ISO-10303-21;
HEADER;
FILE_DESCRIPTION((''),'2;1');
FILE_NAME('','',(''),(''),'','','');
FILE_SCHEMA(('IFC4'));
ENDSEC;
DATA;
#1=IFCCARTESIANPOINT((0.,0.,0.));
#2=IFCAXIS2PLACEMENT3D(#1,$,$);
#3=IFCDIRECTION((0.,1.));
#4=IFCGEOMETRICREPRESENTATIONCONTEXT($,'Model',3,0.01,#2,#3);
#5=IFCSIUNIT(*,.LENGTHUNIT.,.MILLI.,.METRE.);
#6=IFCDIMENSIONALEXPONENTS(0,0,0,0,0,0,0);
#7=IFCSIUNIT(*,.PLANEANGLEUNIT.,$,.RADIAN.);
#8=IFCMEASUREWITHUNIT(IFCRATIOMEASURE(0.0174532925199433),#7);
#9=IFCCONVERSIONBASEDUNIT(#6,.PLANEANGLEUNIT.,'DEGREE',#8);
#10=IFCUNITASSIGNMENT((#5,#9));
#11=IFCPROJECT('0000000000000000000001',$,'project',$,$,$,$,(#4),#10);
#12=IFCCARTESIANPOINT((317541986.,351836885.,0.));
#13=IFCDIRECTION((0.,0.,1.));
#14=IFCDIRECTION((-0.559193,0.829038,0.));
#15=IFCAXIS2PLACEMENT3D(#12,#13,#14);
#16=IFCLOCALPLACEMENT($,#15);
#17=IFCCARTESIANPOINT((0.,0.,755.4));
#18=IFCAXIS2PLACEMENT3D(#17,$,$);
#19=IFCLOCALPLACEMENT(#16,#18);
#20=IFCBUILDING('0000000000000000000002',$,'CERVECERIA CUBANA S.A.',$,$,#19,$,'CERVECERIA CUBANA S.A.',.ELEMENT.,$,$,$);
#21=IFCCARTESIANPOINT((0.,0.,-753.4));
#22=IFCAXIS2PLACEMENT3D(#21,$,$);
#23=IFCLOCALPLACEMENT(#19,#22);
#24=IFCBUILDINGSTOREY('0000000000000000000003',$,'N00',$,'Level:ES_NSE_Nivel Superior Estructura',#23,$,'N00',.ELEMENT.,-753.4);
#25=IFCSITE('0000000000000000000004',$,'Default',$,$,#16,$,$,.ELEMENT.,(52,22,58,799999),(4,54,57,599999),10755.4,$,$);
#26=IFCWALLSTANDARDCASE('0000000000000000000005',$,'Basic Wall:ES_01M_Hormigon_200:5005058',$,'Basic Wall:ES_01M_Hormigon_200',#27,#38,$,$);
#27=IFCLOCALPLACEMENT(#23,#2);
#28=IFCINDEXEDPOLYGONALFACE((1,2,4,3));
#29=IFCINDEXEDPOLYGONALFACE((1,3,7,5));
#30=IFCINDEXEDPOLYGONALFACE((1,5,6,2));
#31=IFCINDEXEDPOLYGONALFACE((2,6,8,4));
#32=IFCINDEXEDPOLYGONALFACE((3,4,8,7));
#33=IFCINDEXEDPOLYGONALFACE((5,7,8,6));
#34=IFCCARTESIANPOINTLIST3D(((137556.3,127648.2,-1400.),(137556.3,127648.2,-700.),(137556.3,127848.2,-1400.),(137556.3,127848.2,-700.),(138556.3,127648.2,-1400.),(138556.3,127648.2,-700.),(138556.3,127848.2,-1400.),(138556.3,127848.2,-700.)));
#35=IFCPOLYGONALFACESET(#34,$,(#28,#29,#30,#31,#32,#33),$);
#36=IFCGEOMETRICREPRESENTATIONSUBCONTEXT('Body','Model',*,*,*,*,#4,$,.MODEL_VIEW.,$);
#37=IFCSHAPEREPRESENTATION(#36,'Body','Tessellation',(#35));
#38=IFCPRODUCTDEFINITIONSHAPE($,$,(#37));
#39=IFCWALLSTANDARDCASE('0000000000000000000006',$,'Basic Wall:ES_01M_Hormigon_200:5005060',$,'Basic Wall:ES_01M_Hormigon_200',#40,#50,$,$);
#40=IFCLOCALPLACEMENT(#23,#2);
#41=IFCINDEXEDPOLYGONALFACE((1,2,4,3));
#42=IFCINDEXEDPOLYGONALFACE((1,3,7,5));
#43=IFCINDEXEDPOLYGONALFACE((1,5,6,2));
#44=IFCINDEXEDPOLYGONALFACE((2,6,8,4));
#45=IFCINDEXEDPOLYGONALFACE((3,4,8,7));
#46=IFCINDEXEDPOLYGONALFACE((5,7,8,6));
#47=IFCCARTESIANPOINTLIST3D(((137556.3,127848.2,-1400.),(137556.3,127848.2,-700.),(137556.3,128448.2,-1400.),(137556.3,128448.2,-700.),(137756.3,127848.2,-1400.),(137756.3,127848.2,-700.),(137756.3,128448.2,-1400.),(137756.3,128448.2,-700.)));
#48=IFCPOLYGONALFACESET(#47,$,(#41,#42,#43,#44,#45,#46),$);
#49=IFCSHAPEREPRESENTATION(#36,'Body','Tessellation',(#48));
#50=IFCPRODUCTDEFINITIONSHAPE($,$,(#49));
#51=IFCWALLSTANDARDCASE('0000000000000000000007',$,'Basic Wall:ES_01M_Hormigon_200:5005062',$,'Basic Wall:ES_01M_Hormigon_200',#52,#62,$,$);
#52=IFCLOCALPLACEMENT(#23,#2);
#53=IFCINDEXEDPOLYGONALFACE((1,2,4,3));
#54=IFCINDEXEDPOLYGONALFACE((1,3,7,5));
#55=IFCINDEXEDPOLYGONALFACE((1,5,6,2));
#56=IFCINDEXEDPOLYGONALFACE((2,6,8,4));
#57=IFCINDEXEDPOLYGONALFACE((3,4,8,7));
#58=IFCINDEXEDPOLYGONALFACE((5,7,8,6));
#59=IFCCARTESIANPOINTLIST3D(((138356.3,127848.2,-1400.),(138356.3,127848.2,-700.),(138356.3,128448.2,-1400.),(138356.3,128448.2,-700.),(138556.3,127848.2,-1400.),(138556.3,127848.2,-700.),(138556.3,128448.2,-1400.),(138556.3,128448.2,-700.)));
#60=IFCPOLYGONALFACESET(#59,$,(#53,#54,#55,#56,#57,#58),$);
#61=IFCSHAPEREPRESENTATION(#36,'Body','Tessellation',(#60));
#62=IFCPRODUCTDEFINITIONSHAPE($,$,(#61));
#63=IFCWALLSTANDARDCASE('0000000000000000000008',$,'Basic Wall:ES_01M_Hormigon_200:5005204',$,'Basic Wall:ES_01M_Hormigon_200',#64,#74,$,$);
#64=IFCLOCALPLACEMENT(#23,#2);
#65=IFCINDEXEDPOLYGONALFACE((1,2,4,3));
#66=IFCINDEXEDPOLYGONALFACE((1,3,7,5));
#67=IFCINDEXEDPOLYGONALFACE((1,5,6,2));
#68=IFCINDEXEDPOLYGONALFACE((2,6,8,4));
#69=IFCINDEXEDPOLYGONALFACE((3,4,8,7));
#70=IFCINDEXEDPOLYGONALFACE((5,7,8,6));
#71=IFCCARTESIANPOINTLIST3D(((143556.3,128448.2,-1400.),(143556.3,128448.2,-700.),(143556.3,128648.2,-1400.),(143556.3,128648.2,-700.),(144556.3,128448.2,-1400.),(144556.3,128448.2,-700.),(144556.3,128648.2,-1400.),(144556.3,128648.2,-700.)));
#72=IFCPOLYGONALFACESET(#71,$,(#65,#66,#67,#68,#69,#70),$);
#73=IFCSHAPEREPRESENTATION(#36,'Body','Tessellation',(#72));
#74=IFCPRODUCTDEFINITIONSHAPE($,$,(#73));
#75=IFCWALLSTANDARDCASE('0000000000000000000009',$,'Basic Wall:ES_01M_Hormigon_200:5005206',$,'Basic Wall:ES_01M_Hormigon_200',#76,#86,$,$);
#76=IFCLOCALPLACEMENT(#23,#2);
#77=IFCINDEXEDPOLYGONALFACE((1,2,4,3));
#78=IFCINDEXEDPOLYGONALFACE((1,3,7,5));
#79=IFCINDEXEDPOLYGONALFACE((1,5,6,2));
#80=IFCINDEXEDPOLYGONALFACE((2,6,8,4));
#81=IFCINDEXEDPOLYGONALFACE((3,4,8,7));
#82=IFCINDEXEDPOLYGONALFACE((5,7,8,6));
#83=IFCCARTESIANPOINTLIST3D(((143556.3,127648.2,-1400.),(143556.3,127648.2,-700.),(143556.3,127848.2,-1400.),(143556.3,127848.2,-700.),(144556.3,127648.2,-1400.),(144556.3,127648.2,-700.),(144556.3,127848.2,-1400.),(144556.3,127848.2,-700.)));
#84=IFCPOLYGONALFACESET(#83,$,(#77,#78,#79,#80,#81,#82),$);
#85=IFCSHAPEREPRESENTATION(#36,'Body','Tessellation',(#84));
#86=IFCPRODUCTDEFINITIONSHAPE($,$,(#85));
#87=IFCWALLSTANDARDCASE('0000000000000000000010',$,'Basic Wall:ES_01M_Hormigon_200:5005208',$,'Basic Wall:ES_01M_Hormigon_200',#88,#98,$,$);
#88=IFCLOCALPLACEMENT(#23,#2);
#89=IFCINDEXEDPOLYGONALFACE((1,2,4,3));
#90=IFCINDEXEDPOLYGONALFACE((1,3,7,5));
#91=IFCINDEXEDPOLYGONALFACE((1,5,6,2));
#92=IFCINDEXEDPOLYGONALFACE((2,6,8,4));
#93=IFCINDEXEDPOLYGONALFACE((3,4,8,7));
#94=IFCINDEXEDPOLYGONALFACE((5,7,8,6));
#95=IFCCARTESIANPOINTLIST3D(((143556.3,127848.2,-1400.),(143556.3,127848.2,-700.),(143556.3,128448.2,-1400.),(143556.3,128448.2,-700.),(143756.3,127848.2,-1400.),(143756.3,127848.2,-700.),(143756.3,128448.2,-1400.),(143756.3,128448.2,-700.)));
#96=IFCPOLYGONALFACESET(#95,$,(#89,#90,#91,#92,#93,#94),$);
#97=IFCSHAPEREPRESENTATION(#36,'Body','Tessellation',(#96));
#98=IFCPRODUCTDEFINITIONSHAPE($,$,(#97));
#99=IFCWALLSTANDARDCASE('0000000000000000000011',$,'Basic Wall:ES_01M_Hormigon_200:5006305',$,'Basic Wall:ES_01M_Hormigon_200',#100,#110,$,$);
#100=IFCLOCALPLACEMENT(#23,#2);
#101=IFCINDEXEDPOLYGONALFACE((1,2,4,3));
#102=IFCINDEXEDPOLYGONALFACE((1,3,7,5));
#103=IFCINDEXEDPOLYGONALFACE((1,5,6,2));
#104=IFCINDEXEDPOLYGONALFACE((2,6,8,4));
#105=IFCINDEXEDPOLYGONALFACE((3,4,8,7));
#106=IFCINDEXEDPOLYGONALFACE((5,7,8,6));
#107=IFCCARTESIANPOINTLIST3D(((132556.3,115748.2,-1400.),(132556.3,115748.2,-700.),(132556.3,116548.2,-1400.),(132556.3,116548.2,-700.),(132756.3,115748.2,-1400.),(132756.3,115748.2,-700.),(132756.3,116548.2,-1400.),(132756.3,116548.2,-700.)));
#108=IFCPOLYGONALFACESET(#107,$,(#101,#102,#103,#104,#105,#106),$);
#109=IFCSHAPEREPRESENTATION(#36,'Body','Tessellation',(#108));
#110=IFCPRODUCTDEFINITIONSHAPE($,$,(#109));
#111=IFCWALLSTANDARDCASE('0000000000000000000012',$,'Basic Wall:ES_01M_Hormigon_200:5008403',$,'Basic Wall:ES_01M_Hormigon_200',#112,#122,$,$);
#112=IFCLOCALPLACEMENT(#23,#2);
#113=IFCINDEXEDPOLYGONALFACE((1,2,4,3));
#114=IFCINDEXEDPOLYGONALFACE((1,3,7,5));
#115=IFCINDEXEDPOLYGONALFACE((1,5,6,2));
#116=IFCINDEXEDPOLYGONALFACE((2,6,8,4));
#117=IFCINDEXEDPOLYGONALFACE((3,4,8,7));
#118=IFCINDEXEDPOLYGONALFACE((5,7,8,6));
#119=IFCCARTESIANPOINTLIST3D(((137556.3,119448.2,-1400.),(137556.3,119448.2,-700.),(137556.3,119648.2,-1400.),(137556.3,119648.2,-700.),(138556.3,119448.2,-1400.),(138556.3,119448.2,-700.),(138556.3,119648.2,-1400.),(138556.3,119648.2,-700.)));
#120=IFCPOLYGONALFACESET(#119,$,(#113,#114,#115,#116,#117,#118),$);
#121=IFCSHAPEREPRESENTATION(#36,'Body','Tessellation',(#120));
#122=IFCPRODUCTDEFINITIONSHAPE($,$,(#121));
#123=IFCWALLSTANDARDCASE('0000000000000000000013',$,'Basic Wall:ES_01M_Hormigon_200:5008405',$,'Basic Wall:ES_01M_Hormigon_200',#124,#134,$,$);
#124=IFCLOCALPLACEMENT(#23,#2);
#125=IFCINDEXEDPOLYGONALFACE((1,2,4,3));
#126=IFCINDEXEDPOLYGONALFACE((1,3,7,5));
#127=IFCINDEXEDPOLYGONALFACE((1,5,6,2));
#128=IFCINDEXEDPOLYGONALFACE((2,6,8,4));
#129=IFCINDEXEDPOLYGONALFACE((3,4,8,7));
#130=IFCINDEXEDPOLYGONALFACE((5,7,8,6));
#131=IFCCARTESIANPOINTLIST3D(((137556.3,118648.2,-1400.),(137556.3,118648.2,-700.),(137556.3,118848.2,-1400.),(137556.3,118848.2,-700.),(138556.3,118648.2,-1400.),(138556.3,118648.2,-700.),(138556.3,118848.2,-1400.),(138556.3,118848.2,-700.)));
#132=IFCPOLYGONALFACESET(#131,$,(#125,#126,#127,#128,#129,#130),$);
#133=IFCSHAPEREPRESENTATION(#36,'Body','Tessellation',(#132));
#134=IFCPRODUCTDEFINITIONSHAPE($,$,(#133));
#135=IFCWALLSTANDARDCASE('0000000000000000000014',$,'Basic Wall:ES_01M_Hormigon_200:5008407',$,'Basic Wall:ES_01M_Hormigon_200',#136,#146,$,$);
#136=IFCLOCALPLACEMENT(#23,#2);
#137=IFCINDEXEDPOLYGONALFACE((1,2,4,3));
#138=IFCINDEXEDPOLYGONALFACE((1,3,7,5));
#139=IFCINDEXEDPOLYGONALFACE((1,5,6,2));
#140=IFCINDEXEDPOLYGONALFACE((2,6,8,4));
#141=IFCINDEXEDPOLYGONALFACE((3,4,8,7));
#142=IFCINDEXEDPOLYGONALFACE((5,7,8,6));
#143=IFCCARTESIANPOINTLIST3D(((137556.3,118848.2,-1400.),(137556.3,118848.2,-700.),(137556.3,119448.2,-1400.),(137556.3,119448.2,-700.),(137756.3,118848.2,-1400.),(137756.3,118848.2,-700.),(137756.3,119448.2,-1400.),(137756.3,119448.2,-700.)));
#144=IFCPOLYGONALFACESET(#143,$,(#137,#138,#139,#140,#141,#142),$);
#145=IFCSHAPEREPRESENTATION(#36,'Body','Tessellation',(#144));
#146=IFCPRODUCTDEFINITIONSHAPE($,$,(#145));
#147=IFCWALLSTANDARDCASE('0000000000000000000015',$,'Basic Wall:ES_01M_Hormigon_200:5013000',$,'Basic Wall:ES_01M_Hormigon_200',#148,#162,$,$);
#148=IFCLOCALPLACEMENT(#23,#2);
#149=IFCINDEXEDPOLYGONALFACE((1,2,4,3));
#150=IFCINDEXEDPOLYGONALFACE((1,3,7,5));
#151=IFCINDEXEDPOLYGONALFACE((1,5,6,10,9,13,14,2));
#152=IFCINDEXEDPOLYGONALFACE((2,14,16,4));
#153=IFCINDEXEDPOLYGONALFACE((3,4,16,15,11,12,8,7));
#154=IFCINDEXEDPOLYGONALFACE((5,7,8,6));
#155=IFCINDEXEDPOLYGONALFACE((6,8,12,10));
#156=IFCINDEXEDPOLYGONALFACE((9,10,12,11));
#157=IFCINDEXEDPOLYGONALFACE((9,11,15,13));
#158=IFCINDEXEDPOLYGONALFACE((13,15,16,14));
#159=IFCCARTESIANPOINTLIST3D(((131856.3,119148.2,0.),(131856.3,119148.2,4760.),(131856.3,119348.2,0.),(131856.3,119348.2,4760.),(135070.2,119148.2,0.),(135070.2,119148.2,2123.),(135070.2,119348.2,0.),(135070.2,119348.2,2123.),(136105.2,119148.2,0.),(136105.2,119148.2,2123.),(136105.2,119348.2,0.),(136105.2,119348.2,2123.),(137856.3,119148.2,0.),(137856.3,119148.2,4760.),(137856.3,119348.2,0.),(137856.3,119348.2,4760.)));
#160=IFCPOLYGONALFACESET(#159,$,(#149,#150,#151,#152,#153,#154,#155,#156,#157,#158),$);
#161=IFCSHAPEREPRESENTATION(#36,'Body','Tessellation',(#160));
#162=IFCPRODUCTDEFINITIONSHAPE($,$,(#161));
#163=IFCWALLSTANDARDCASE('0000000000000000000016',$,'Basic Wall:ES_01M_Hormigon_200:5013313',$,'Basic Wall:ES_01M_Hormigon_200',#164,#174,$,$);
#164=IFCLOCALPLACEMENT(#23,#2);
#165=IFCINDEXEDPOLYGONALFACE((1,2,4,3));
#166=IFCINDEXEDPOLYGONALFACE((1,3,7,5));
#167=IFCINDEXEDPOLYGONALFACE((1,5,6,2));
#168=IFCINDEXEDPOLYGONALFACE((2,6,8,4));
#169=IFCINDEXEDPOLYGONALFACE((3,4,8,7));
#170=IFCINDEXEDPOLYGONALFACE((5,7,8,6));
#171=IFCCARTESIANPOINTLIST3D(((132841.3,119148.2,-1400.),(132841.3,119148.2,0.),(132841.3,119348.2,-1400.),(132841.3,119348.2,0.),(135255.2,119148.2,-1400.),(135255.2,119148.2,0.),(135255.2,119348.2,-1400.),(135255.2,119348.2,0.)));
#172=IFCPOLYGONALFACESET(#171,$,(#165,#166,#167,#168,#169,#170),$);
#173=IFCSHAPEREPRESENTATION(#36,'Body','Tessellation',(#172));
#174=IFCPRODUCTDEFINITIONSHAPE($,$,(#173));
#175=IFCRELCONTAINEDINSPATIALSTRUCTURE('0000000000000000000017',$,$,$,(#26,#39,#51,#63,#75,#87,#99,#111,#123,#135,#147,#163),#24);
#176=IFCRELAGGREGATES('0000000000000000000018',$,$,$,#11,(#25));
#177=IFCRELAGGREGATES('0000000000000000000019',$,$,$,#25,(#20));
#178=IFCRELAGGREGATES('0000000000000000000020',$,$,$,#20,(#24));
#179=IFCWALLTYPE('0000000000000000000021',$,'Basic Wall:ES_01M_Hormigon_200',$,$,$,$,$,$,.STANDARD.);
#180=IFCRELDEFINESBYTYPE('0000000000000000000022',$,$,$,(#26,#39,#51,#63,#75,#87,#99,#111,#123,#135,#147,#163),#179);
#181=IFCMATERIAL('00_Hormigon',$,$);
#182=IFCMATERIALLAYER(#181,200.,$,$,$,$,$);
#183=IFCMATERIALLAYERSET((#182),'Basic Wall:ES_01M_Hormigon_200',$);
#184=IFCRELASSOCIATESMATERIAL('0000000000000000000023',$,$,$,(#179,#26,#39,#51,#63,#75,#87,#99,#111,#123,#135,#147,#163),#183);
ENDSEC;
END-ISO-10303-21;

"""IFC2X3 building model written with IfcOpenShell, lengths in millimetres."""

from ifc_helpers import new_model, entity, si_unit, converted_unit, direction, frame, frame_2d, origin, place, context, subcontext, project, spatial, rectangle, extrude, material, layer, layer_set, layer_usage, type_object, element, save


model = new_model("IFC2X3")

# Units and contexts
model_context = context("Model", 3, precision=0.01, world=origin(), true_north=direction((0.0, 1.0)))
body_context = subcontext(model_context, "Body", "Model", "MODEL_VIEW")
ifc_project = project(units=[si_unit("LENGTHUNIT", "METRE", prefix="MILLI"), converted_unit("PLANEANGLEUNIT", "DEGREE", entity("IfcRatioMeasure", 0.0174532925199433), si_unit("PLANEANGLEUNIT", "RADIAN"), dimensions=[0, 0, 0, 0, 0, 0, 0])], contexts=[model_context])

# Site, building, storey
site_placement = place(None, frame((317541986.0, 351836885.0, 0.0), z_axis=(0.0, 0.0, 1.0), x_axis=(-0.559193, 0.829038, 0.0)))
site = spatial("IfcSite", under=ifc_project, at=site_placement, Name="Default", CompositionType="ELEMENT", RefLatitude=(52, 22, 58, 799999), RefLongitude=(4, 54, 57, 599999), RefElevation=10755.4)
building_placement = place(site_placement, frame((0.0, 0.0, 755.4)))
building = spatial("IfcBuilding", under=site, at=building_placement, Name="CERVECERIA CUBANA S.A.", LongName="CERVECERIA CUBANA S.A.", CompositionType="ELEMENT")
storey_placement = place(building_placement, frame((0.0, 0.0, -753.4)))
storey = spatial("IfcBuildingStorey", under=building, at=storey_placement, Name="N00", ObjectType="Level:ES_NSE_Nivel Superior Estructura", LongName="N00", CompositionType="ELEMENT", Elevation=-753.4)

# Walls
ifc_material = material(Name="00_Hormigon")
ifc_layer = layer(ifc_material, 200.0)
ifc_layer_set = layer_set([ifc_layer], Name="Basic Wall:ES_01M_Hormigon_200")
wall_type = type_object("IfcWallType", Name="Basic Wall:ES_01M_Hormigon_200", PredefinedType="STANDARD", material=ifc_layer_set)
ifc_layer_usage_1 = layer_usage(ifc_layer_set, "AXIS2", "POSITIVE", -100.0)
wall_1_placement = place(storey_placement, frame((137556.3, 127748.2, -1400.0)))
element("IfcWallStandardCase", 1, at=wall_1_placement, inside=storey, type_object=wall_type, material=ifc_layer_usage_1, Name="Basic Wall:ES_01M_Hormigon_200:5005058", ObjectType="Basic Wall:ES_01M_Hormigon_200", context=body_context, shape_type="SweptSolid", body=[
    extrude(rectangle(XDim=1000.0, YDim=200.0, at=frame_2d((500.0, 0.0), x_axis=(-1.0, 0.0))), origin(), (0.0, 0.0, 1.0), 700.0),
])
ifc_layer_usage_2 = layer_usage(ifc_layer_set, "AXIS2", "POSITIVE", -100.0)
wall_2_placement = place(storey_placement, frame((137656.3, 128448.2, -1400.0), z_axis=(0.0, 0.0, 1.0), x_axis=(0.0, -1.0, 0.0)))
element("IfcWallStandardCase", 2, at=wall_2_placement, inside=storey, type_object=wall_type, material=ifc_layer_usage_2, Name="Basic Wall:ES_01M_Hormigon_200:5005060", ObjectType="Basic Wall:ES_01M_Hormigon_200", context=body_context, shape_type="SweptSolid", body=[
    extrude(rectangle(XDim=600.0, YDim=200.0, at=frame_2d((300.0, 0.0), x_axis=(-1.0, 0.0))), origin(), (0.0, 0.0, 1.0), 700.0),
])
ifc_layer_usage_3 = layer_usage(ifc_layer_set, "AXIS2", "NEGATIVE", 100.0)
wall_3_placement = place(storey_placement, frame((138456.3, 128448.2, -1400.0), z_axis=(0.0, 0.0, 1.0), x_axis=(0.0, -1.0, 0.0)))
element("IfcWallStandardCase", 3, at=wall_3_placement, inside=storey, type_object=wall_type, material=ifc_layer_usage_3, Name="Basic Wall:ES_01M_Hormigon_200:5005062", ObjectType="Basic Wall:ES_01M_Hormigon_200", context=body_context, shape_type="SweptSolid", body=[
    extrude(rectangle(XDim=600.0, YDim=200.0, at=frame_2d((300.0, 0.0), x_axis=(-1.0, 0.0))), origin(), (0.0, 0.0, 1.0), 700.0),
])
ifc_layer_usage_4 = layer_usage(ifc_layer_set, "AXIS2", "NEGATIVE", 100.0)
wall_4_placement = place(storey_placement, frame((143556.3, 128548.2, -1400.0)))
element("IfcWallStandardCase", 4, at=wall_4_placement, inside=storey, type_object=wall_type, material=ifc_layer_usage_4, Name="Basic Wall:ES_01M_Hormigon_200:5005204", ObjectType="Basic Wall:ES_01M_Hormigon_200", context=body_context, shape_type="SweptSolid", body=[
    extrude(rectangle(XDim=1000.0, YDim=200.0, at=frame_2d((500.0, 0.0), x_axis=(-1.0, 0.0))), origin(), (0.0, 0.0, 1.0), 700.0),
])
ifc_layer_usage_5 = layer_usage(ifc_layer_set, "AXIS2", "POSITIVE", -100.0)
wall_5_placement = place(storey_placement, frame((143556.3, 127748.2, -1400.0)))
element("IfcWallStandardCase", 5, at=wall_5_placement, inside=storey, type_object=wall_type, material=ifc_layer_usage_5, Name="Basic Wall:ES_01M_Hormigon_200:5005206", ObjectType="Basic Wall:ES_01M_Hormigon_200", context=body_context, shape_type="SweptSolid", body=[
    extrude(rectangle(XDim=1000.0, YDim=200.0, at=frame_2d((500.0, 0.0), x_axis=(-1.0, 0.0))), origin(), (0.0, 0.0, 1.0), 700.0),
])
ifc_layer_usage_6 = layer_usage(ifc_layer_set, "AXIS2", "POSITIVE", -100.0)
wall_6_placement = place(storey_placement, frame((143656.3, 128448.2, -1400.0), z_axis=(0.0, 0.0, 1.0), x_axis=(0.0, -1.0, 0.0)))
element("IfcWallStandardCase", 6, at=wall_6_placement, inside=storey, type_object=wall_type, material=ifc_layer_usage_6, Name="Basic Wall:ES_01M_Hormigon_200:5005208", ObjectType="Basic Wall:ES_01M_Hormigon_200", context=body_context, shape_type="SweptSolid", body=[
    extrude(rectangle(XDim=600.0, YDim=200.0, at=frame_2d((300.0, 0.0), x_axis=(-1.0, 0.0))), origin(), (0.0, 0.0, 1.0), 700.0),
])
ifc_layer_usage_7 = layer_usage(ifc_layer_set, "AXIS2", "NEGATIVE", 100.0)
wall_7_placement = place(storey_placement, frame((132656.3, 116548.2, -1400.0), z_axis=(0.0, 0.0, 1.0), x_axis=(0.0, -1.0, 0.0)))
element("IfcWallStandardCase", 7, at=wall_7_placement, inside=storey, type_object=wall_type, material=ifc_layer_usage_7, Name="Basic Wall:ES_01M_Hormigon_200:5006305", ObjectType="Basic Wall:ES_01M_Hormigon_200", context=body_context, shape_type="SweptSolid", body=[
    extrude(rectangle(XDim=800.0, YDim=200.0, at=frame_2d((400.0, 0.0), x_axis=(-1.0, 0.0))), origin(), (0.0, 0.0, 1.0), 700.0),
])
ifc_layer_usage_8 = layer_usage(ifc_layer_set, "AXIS2", "NEGATIVE", 100.0)
wall_8_placement = place(storey_placement, frame((137556.3, 119548.2, -1400.0)))
element("IfcWallStandardCase", 8, at=wall_8_placement, inside=storey, type_object=wall_type, material=ifc_layer_usage_8, Name="Basic Wall:ES_01M_Hormigon_200:5008403", ObjectType="Basic Wall:ES_01M_Hormigon_200", context=body_context, shape_type="SweptSolid", body=[
    extrude(rectangle(XDim=1000.0, YDim=200.0, at=frame_2d((500.0, 0.0), x_axis=(-1.0, 0.0))), origin(), (0.0, 0.0, 1.0), 700.0),
])
ifc_layer_usage_9 = layer_usage(ifc_layer_set, "AXIS2", "POSITIVE", -100.0)
wall_9_placement = place(storey_placement, frame((137556.3, 118748.2, -1400.0)))
element("IfcWallStandardCase", 9, at=wall_9_placement, inside=storey, type_object=wall_type, material=ifc_layer_usage_9, Name="Basic Wall:ES_01M_Hormigon_200:5008405", ObjectType="Basic Wall:ES_01M_Hormigon_200", context=body_context, shape_type="SweptSolid", body=[
    extrude(rectangle(XDim=1000.0, YDim=200.0, at=frame_2d((500.0, 0.0), x_axis=(-1.0, 0.0))), origin(), (0.0, 0.0, 1.0), 700.0),
])
ifc_layer_usage_10 = layer_usage(ifc_layer_set, "AXIS2", "POSITIVE", -100.0)
wall_10_placement = place(storey_placement, frame((137656.3, 119448.2, -1400.0), z_axis=(0.0, 0.0, 1.0), x_axis=(0.0, -1.0, 0.0)))
element("IfcWallStandardCase", 10, at=wall_10_placement, inside=storey, type_object=wall_type, material=ifc_layer_usage_10, Name="Basic Wall:ES_01M_Hormigon_200:5008407", ObjectType="Basic Wall:ES_01M_Hormigon_200", context=body_context, shape_type="SweptSolid", body=[
    extrude(rectangle(XDim=600.0, YDim=200.0, at=frame_2d((300.0, 0.0), x_axis=(-1.0, 0.0))), origin(), (0.0, 0.0, 1.0), 700.0),
])

# Wall, opening
ifc_layer_usage_11 = layer_usage(ifc_layer_set, "AXIS2", "NEGATIVE", 100.0)
wall_11_placement = place(storey_placement, frame((131856.3, 119248.2, 0.0)))
wall_11 = element("IfcWallStandardCase", 11, at=wall_11_placement, inside=storey, type_object=wall_type, material=ifc_layer_usage_11, Name="Basic Wall:ES_01M_Hormigon_200:5013000", ObjectType="Basic Wall:ES_01M_Hormigon_200", context=body_context, shape_type="SweptSolid", body=[
    extrude(rectangle(XDim=6000.0, YDim=200.0, at=frame_2d((3000.0, 0.0), x_axis=(-1.0, 0.0))), origin(), (0.0, 0.0, 1.0), 4760.0),
])
opening_placement = place(wall_11_placement, frame((-131856.3, -119248.2, 0.0)))
element("IfcOpeningElement", 12, at=opening_placement, cuts=wall_11, ObjectType="Opening", context=body_context, shape_type="SweptSolid", body=[
    extrude(rectangle(XDim=2123.0, YDim=1035.0, at=frame_2d((0.0, 0.0), x_axis=(1.0, 0.0))), frame((135587.7, 117824.2, 1061.5), z_axis=(0.0, 1.0, 0.0), x_axis=(0.0, 0.0, -1.0)), (0.0, 0.0, 1.0), 3048.0),
])

# Wall
ifc_layer_usage_12 = layer_usage(ifc_layer_set, "AXIS2", "NEGATIVE", 100.0)
wall_12_placement = place(storey_placement, frame((132841.3, 119248.2, -1400.0)))
element("IfcWallStandardCase", 13, at=wall_12_placement, inside=storey, type_object=wall_type, material=ifc_layer_usage_12, Name="Basic Wall:ES_01M_Hormigon_200:5013313", ObjectType="Basic Wall:ES_01M_Hormigon_200", context=body_context, shape_type="SweptSolid", body=[
    extrude(rectangle(XDim=2413.8, YDim=200.0, at=frame_2d((1206.9, 0.0), x_axis=(-1.0, 0.0))), origin(), (0.0, 0.0, 1.0), 1400.0),
])

save(model, "model.ifc")
